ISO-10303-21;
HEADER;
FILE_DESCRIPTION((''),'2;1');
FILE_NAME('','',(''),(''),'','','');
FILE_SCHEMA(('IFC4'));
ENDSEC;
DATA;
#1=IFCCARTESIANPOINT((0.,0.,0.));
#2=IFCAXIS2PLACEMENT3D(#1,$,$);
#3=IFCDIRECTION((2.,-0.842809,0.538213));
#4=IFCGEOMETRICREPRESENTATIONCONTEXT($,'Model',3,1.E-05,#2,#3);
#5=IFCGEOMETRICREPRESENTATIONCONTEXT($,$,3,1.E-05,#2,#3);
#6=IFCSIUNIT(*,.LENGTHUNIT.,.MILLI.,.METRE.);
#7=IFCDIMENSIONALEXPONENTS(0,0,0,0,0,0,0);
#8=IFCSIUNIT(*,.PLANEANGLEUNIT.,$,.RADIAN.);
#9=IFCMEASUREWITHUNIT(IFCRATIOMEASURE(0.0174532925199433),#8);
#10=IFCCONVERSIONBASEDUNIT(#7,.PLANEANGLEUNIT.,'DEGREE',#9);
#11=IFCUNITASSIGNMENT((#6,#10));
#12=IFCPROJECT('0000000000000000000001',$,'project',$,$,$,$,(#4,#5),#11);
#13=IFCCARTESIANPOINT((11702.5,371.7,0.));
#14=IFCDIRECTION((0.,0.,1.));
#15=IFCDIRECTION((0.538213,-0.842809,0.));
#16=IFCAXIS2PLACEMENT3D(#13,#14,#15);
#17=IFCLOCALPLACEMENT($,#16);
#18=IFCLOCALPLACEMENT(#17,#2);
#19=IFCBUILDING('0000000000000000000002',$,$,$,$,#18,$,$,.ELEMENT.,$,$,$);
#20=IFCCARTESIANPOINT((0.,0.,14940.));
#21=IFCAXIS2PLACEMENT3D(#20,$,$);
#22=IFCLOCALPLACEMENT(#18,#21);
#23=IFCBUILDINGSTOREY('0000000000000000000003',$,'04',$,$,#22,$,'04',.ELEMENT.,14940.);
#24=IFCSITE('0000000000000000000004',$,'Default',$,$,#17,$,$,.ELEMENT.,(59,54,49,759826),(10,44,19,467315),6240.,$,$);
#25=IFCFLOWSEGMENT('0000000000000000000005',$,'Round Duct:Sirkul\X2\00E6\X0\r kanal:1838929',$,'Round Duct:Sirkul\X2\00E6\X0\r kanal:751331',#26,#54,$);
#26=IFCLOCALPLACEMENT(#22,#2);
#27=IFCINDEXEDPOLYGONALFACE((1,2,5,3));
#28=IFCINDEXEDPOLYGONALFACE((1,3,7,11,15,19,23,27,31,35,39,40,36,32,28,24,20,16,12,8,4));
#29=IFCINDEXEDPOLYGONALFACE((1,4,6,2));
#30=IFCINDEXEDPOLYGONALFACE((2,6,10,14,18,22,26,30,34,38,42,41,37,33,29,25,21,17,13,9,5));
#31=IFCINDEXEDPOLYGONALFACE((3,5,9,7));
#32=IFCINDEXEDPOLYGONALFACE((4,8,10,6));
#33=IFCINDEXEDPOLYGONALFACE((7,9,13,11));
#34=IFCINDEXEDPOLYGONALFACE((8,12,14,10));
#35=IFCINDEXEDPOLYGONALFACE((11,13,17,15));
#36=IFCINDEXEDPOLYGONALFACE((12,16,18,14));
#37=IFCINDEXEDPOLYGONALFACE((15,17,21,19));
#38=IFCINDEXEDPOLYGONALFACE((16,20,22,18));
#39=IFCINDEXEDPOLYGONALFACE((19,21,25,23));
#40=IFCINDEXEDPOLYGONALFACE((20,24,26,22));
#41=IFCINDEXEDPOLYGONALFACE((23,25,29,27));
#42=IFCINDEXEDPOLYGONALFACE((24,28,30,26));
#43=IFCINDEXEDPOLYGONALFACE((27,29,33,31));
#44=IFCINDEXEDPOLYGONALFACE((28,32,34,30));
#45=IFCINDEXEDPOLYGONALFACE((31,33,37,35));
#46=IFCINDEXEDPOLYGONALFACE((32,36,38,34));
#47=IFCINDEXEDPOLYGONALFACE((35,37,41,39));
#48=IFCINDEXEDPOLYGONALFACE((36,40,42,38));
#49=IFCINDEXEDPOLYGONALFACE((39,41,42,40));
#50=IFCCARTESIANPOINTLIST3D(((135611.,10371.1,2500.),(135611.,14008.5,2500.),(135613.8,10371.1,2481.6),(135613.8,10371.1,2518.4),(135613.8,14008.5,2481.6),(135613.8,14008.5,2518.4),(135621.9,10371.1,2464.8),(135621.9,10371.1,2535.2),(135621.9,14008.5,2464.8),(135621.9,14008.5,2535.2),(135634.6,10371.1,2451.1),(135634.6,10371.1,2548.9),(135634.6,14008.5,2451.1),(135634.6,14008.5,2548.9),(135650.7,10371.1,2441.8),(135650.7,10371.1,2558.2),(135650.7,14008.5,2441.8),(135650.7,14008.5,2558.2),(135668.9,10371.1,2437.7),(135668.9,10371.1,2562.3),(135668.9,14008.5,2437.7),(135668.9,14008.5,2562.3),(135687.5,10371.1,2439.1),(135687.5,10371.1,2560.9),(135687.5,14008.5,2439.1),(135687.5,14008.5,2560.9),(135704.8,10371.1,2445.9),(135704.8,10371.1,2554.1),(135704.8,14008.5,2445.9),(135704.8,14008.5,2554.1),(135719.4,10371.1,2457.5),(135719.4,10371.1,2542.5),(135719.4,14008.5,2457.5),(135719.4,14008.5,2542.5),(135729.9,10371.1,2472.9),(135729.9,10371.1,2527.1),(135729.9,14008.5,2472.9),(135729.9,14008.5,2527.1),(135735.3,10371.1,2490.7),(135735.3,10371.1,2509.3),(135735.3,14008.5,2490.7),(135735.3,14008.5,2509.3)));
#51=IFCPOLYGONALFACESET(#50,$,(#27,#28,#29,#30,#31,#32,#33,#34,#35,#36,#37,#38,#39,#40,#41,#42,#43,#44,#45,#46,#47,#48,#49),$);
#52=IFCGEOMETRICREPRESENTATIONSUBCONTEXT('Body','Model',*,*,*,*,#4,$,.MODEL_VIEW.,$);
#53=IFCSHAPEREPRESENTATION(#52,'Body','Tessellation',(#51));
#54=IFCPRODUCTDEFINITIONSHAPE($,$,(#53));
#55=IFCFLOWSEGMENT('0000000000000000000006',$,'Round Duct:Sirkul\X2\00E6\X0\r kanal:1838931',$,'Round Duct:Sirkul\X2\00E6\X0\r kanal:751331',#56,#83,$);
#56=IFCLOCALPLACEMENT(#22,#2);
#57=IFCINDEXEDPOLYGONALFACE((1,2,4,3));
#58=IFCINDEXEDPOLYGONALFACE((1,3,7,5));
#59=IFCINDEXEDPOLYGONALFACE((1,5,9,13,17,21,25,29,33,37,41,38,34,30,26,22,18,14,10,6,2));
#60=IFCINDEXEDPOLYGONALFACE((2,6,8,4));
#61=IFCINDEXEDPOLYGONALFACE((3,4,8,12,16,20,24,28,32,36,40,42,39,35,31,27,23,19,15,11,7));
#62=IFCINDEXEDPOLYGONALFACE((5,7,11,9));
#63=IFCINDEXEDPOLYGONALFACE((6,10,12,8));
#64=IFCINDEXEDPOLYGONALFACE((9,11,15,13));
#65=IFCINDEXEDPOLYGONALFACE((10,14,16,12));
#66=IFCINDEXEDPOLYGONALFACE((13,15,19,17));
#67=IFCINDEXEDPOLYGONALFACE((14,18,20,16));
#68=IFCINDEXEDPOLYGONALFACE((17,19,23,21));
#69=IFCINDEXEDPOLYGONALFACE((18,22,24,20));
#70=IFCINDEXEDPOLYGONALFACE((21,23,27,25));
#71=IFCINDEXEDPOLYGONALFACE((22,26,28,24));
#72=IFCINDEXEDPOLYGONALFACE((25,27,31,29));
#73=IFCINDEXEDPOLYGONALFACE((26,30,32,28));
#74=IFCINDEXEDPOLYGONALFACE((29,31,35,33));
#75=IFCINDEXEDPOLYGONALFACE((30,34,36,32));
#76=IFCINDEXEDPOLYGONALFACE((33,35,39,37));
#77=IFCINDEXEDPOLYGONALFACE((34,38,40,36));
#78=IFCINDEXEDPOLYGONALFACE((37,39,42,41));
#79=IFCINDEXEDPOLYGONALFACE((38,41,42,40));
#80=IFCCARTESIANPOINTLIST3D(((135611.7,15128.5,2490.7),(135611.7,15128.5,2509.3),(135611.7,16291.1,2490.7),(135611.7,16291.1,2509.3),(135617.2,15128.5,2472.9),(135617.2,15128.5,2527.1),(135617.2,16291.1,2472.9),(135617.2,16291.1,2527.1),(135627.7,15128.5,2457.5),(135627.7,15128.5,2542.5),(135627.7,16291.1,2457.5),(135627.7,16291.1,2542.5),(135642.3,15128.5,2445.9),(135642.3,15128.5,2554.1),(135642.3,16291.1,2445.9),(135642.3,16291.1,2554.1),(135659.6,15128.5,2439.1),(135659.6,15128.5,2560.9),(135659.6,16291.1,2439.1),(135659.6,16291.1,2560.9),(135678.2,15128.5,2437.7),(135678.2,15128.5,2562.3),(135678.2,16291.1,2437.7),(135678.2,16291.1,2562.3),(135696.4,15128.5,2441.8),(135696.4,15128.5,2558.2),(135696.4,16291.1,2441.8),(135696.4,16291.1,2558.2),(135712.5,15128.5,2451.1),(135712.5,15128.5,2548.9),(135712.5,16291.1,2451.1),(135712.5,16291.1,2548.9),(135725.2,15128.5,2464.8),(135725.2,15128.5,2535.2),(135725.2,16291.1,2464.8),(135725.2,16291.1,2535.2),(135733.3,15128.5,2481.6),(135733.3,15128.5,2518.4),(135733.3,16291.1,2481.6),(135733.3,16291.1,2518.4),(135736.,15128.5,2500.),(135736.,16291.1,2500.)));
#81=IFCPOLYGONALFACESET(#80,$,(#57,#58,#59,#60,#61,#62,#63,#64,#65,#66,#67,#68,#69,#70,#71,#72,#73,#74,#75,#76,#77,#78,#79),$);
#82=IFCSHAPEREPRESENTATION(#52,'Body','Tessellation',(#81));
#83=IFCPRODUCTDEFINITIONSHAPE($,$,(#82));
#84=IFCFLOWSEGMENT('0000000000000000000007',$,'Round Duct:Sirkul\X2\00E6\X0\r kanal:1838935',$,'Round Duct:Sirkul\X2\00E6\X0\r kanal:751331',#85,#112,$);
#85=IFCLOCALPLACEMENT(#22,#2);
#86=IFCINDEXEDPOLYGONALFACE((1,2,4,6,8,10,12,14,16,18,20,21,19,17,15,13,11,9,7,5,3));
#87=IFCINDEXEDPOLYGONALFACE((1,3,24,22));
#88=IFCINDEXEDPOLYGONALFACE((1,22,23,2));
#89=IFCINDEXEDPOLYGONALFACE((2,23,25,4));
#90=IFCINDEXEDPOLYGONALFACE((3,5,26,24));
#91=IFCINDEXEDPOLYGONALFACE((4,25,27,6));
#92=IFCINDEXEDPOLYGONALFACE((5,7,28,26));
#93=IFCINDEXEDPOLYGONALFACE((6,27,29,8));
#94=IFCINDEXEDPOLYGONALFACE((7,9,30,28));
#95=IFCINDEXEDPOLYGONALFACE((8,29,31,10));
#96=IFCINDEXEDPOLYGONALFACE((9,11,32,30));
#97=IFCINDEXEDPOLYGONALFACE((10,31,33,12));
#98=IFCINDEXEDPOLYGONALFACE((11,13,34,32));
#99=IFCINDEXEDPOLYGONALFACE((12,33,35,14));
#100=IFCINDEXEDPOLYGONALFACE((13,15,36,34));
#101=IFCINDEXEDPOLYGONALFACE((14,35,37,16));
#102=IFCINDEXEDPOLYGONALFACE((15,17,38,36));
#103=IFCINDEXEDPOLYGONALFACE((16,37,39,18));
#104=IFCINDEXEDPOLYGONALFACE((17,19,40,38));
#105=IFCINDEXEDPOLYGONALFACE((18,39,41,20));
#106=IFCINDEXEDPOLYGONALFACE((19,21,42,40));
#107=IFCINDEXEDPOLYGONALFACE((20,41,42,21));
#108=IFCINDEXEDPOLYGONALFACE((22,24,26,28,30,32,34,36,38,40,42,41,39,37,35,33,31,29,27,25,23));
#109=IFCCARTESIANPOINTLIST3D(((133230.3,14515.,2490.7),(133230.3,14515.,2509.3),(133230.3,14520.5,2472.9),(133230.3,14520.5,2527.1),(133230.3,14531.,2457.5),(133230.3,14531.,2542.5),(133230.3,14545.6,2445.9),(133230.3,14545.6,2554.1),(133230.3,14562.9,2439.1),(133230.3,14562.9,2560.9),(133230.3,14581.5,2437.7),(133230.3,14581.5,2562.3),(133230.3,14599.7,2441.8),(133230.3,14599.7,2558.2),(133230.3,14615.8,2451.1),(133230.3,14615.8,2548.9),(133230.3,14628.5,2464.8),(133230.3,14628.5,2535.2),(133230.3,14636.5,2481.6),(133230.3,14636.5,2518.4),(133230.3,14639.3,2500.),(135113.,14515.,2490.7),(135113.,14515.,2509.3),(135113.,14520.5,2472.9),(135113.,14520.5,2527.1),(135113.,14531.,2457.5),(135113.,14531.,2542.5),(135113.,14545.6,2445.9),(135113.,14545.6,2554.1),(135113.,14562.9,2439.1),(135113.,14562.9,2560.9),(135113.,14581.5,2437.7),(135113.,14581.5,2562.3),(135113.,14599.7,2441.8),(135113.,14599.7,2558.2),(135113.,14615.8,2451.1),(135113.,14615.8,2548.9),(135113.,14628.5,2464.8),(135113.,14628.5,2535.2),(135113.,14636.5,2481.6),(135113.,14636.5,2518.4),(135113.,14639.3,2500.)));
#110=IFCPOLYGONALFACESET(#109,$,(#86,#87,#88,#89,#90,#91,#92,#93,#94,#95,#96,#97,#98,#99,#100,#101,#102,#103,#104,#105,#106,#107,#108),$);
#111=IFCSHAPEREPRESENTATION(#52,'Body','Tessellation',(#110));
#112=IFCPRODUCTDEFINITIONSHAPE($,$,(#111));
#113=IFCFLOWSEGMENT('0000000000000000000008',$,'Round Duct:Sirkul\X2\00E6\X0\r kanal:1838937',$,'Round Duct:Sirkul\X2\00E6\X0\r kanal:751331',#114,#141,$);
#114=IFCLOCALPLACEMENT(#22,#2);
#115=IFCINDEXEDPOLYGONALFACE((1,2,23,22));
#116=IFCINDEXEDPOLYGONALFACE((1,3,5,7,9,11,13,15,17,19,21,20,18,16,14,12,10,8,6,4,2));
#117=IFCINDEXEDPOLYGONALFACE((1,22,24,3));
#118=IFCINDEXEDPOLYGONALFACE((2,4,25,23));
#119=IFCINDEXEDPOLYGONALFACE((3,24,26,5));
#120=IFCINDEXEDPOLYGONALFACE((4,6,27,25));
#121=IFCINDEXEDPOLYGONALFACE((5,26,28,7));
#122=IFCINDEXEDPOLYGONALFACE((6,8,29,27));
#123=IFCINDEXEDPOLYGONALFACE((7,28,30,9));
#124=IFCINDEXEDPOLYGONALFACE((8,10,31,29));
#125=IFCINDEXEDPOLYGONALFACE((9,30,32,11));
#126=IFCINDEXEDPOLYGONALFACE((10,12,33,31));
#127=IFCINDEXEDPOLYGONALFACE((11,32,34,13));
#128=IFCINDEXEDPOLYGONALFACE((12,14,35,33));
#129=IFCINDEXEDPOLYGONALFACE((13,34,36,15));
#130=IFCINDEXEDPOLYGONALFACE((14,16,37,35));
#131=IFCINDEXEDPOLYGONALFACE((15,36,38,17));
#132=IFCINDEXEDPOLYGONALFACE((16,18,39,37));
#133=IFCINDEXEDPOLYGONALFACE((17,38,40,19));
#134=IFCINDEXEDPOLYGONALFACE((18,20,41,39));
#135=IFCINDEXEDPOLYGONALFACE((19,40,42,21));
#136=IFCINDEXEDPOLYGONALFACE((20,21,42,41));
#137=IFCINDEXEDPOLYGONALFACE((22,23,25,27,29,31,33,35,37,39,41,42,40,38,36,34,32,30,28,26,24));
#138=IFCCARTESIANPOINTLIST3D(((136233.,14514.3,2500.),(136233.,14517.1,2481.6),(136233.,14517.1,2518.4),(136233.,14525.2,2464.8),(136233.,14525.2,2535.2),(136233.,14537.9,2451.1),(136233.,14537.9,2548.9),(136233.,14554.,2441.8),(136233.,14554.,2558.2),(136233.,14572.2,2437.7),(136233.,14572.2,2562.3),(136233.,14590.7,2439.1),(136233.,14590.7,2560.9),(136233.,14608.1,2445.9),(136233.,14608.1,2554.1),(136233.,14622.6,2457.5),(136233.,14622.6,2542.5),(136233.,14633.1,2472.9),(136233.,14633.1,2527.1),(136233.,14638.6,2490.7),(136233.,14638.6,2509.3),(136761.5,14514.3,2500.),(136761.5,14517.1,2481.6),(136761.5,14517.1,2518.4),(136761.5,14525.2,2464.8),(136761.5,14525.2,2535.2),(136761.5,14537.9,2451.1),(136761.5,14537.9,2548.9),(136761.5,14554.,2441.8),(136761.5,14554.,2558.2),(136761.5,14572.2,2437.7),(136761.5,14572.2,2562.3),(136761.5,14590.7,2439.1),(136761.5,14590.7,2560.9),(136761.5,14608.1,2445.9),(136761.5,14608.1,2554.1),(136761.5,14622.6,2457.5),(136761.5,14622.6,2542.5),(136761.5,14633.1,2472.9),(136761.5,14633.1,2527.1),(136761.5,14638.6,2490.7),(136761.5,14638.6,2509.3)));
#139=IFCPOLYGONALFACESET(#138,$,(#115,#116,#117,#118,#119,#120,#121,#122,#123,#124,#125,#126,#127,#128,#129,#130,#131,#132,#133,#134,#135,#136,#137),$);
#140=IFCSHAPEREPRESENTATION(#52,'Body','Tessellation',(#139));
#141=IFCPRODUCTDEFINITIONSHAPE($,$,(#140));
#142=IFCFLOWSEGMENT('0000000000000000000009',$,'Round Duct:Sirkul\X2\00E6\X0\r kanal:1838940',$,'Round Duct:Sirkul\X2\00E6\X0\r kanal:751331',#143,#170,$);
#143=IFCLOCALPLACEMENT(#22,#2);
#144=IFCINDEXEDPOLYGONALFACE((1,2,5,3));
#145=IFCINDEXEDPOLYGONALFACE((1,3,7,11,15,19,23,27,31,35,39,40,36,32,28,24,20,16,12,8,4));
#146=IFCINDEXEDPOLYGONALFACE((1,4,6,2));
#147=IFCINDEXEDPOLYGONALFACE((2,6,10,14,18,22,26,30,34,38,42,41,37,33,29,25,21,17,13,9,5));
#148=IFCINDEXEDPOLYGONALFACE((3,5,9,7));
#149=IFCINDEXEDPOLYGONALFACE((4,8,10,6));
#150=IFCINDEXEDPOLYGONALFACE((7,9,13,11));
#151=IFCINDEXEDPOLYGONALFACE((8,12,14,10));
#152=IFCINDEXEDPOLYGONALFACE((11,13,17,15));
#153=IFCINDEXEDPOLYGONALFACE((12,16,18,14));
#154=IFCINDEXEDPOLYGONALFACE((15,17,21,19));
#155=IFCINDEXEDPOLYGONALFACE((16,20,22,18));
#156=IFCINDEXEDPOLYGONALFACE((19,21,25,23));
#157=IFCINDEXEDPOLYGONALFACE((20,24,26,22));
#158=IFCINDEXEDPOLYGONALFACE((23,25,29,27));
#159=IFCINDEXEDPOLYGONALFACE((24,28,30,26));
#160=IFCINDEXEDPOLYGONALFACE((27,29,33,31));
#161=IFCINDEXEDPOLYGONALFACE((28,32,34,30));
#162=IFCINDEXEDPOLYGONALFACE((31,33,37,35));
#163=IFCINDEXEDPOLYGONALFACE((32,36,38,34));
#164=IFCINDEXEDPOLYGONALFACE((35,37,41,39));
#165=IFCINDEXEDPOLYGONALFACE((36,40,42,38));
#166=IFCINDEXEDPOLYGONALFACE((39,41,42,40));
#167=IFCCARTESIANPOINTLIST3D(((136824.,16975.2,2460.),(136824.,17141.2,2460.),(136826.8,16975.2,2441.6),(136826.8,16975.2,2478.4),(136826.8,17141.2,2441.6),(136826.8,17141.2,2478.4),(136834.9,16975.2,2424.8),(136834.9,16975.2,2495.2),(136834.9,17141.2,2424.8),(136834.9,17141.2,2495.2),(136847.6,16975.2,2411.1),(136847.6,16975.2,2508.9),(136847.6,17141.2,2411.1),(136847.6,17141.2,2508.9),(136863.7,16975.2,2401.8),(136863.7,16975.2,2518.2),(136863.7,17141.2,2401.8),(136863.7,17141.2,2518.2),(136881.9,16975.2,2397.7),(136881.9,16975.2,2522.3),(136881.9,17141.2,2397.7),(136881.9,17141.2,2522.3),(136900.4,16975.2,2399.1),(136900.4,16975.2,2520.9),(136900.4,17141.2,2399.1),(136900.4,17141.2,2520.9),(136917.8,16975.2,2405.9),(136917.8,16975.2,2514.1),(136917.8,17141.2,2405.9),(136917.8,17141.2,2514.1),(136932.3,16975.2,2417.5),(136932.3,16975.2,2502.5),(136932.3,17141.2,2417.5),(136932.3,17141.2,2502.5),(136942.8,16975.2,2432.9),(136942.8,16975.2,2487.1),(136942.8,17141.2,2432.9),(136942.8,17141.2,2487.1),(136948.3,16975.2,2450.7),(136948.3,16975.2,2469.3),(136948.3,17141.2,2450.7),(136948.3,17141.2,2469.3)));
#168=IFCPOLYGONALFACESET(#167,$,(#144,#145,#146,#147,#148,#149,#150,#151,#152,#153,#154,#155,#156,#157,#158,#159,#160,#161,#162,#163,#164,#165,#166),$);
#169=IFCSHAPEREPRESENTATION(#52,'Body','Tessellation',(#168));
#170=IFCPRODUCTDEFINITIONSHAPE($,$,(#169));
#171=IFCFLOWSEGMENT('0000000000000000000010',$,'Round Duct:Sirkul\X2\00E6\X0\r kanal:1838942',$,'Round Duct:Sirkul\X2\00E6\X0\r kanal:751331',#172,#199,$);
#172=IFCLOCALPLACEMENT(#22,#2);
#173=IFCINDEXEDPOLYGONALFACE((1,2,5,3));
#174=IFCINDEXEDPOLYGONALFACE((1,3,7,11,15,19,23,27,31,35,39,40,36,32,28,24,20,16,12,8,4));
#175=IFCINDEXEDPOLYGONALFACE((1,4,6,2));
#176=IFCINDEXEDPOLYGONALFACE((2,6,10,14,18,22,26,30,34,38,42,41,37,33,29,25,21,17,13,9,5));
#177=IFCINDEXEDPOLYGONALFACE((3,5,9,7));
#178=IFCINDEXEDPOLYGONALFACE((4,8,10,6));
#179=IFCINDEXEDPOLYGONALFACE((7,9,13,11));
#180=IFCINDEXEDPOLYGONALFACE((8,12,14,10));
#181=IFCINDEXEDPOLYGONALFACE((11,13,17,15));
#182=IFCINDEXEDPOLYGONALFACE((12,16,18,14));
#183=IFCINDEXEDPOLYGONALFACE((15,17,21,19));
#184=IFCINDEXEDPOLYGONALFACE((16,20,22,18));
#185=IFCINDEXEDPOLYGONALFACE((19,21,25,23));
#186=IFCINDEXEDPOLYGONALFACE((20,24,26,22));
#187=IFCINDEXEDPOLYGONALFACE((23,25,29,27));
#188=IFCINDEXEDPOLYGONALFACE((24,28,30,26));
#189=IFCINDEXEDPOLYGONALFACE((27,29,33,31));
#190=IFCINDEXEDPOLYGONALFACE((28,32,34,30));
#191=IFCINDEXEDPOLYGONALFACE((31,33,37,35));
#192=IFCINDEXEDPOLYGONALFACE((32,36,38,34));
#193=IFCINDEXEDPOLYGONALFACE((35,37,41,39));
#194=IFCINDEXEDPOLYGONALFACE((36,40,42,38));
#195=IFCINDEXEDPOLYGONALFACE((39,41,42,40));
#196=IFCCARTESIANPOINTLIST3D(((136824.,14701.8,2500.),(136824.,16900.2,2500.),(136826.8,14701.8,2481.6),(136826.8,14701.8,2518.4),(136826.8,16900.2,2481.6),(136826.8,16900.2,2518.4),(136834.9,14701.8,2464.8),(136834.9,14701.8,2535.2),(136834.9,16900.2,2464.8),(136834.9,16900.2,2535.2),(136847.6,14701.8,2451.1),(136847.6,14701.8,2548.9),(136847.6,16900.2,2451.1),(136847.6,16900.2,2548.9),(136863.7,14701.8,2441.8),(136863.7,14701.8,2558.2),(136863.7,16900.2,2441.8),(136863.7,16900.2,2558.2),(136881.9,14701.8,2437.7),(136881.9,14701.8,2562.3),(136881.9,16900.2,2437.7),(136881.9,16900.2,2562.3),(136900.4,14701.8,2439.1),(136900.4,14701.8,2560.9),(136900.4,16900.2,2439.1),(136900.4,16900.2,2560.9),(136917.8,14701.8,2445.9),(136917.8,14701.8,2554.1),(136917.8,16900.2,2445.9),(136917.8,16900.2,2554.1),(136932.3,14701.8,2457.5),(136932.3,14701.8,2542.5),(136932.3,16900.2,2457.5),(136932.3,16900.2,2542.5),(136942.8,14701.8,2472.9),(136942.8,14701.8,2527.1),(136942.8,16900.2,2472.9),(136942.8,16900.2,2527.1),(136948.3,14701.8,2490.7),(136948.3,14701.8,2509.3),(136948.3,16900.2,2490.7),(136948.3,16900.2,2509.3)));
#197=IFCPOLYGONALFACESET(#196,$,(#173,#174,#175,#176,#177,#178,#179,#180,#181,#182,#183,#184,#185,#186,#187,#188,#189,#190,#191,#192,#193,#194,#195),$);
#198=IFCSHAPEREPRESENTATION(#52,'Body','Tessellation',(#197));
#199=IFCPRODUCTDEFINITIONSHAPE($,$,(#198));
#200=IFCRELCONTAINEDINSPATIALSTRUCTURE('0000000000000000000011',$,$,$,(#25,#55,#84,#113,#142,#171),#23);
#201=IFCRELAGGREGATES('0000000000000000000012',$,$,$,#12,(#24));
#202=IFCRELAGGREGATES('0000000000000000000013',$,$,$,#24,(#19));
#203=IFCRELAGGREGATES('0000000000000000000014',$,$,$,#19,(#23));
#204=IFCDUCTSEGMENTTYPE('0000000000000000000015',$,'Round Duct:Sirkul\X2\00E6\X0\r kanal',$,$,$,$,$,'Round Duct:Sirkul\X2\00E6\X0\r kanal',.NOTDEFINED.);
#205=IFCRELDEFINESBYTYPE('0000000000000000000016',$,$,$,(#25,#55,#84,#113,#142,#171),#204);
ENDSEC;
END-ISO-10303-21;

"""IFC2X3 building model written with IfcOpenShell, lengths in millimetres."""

from ifc_helpers import new_model, entity, si_unit, converted_unit, direction, frame, frame_2d, origin, origin_2d_with_axis, place, context, subcontext, project, spatial, circle, extrude, type_object, element, save


model = new_model("IFC2X3")

# Units and contexts
model_context = context("Model", 3, precision=1e-05, world=origin(), true_north=direction((2.0, -0.842809, 0.538213)))
context_of_model = context(None, 3, precision=1e-05, world=origin(), true_north=direction((2.0, -0.842809, 0.538213)))
body_context = subcontext(model_context, "Body", "Model", "MODEL_VIEW")
ifc_project = project(units=[si_unit("LENGTHUNIT", "METRE", prefix="MILLI"), converted_unit("PLANEANGLEUNIT", "DEGREE", entity("IfcRatioMeasure", 0.0174532925199433), si_unit("PLANEANGLEUNIT", "RADIAN"), dimensions=[0, 0, 0, 0, 0, 0, 0])], contexts=[model_context, context_of_model])

# Site, building, storey
site_placement = place(None, frame((11702.5, 371.7, 0.0), z_axis=(0.0, 0.0, 1.0), x_axis=(0.538213, -0.842809, 0.0)))
site = spatial("IfcSite", under=ifc_project, at=site_placement, Name="Default", CompositionType="ELEMENT", RefLatitude=(59, 54, 49, 759826), RefLongitude=(10, 44, 19, 467315), RefElevation=6240.0)
building_placement = place(site_placement, origin())
building = spatial("IfcBuilding", under=site, at=building_placement, CompositionType="ELEMENT")
storey_placement = place(building_placement, frame((0.0, 0.0, 14940.0)))
storey = spatial("IfcBuildingStorey", under=building, at=storey_placement, Name="04", LongName="04", CompositionType="ELEMENT", Elevation=14940.0)

# Flow segments
duct_segment_type_1 = type_object("IfcDuctSegmentType", Name="Round Duct:Sirkulær kanal", ElementType="Round Duct:Sirkulær kanal", PredefinedType="NOTDEFINED")
flow_segment_1_placement = place(storey_placement, origin())
element("IfcFlowSegment", 1, at=flow_segment_1_placement, inside=storey, type_object=duct_segment_type_1, Name="Round Duct:Sirkulær kanal:1838929", ObjectType="Round Duct:Sirkulær kanal:751331", context=body_context, shape_type="SweptSolid", body=[
    extrude(circle(Radius=62.5, at=frame_2d((0.0, 0.0), x_axis=(1.0, 0.0))), frame((135673.5, 10371.1, 2500.0), z_axis=(0.0, 1.0, 0.0), x_axis=(-1.0, 0.0, 0.0)), (0.0, 0.0, 1.0), 3637.4),
])
flow_segment_2_placement = place(storey_placement, origin())
element("IfcFlowSegment", 2, at=flow_segment_2_placement, inside=storey, type_object=duct_segment_type_1, Name="Round Duct:Sirkulær kanal:1838931", ObjectType="Round Duct:Sirkulær kanal:751331", context=body_context, shape_type="SweptSolid", body=[
    extrude(circle(Radius=62.5, at=origin_2d_with_axis()), frame((135673.5, 15128.5, 2500.0), z_axis=(0.0, 1.0, 0.0), x_axis=(1.0, 0.0, 0.0)), (0.0, 0.0, 1.0), 1162.6),
])
flow_segment_3_placement = place(storey_placement, origin())
element("IfcFlowSegment", 3, at=flow_segment_3_placement, inside=storey, type_object=duct_segment_type_1, Name="Round Duct:Sirkulær kanal:1838935", ObjectType="Round Duct:Sirkulær kanal:751331", context=body_context, shape_type="SweptSolid", body=[
    extrude(circle(Radius=62.5, at=frame_2d((0.0, 0.0), x_axis=(1.0, 0.0))), frame((133230.3, 14576.8, 2500.0), z_axis=(1.0, 0.0, 0.0), x_axis=(0.0, 1.0, 0.0)), (0.0, 0.0, 1.0), 1882.7),
])
flow_segment_4_placement = place(storey_placement, origin())
element("IfcFlowSegment", 4, at=flow_segment_4_placement, inside=storey, type_object=duct_segment_type_1, Name="Round Duct:Sirkulær kanal:1838937", ObjectType="Round Duct:Sirkulær kanal:751331", context=body_context, shape_type="SweptSolid", body=[
    extrude(circle(Radius=62.5, at=origin_2d_with_axis()), frame((136233.0, 14576.8, 2500.0), z_axis=(1.0, 0.0, 0.0), x_axis=(0.0, -1.0, 0.0)), (0.0, 0.0, 1.0), 528.5),
])
flow_segment_5_placement = place(storey_placement, origin())
element("IfcFlowSegment", 5, at=flow_segment_5_placement, inside=storey, type_object=duct_segment_type_1, Name="Round Duct:Sirkulær kanal:1838940", ObjectType="Round Duct:Sirkulær kanal:751331", context=body_context, shape_type="SweptSolid", body=[
    extrude(circle(Radius=62.5, at=origin_2d_with_axis()), frame((136886.5, 16975.2, 2460.0), z_axis=(0.000011, 1.0, 0.0), x_axis=(-1.0, 0.000011, 0.0)), (0.0, 0.0, 1.0), 166.0),
])
flow_segment_6_placement = place(storey_placement, origin())
element("IfcFlowSegment", 6, at=flow_segment_6_placement, inside=storey, type_object=duct_segment_type_1, Name="Round Duct:Sirkulær kanal:1838942", ObjectType="Round Duct:Sirkulær kanal:751331", context=body_context, shape_type="SweptSolid", body=[
    extrude(circle(Radius=62.5, at=origin_2d_with_axis()), frame((136886.5, 14701.8, 2500.0), z_axis=(0.0, 1.0, 0.0), x_axis=(-1.0, 0.0, 0.0)), (0.0, 0.0, 1.0), 2198.4),
])

save(model, "model.ifc")
